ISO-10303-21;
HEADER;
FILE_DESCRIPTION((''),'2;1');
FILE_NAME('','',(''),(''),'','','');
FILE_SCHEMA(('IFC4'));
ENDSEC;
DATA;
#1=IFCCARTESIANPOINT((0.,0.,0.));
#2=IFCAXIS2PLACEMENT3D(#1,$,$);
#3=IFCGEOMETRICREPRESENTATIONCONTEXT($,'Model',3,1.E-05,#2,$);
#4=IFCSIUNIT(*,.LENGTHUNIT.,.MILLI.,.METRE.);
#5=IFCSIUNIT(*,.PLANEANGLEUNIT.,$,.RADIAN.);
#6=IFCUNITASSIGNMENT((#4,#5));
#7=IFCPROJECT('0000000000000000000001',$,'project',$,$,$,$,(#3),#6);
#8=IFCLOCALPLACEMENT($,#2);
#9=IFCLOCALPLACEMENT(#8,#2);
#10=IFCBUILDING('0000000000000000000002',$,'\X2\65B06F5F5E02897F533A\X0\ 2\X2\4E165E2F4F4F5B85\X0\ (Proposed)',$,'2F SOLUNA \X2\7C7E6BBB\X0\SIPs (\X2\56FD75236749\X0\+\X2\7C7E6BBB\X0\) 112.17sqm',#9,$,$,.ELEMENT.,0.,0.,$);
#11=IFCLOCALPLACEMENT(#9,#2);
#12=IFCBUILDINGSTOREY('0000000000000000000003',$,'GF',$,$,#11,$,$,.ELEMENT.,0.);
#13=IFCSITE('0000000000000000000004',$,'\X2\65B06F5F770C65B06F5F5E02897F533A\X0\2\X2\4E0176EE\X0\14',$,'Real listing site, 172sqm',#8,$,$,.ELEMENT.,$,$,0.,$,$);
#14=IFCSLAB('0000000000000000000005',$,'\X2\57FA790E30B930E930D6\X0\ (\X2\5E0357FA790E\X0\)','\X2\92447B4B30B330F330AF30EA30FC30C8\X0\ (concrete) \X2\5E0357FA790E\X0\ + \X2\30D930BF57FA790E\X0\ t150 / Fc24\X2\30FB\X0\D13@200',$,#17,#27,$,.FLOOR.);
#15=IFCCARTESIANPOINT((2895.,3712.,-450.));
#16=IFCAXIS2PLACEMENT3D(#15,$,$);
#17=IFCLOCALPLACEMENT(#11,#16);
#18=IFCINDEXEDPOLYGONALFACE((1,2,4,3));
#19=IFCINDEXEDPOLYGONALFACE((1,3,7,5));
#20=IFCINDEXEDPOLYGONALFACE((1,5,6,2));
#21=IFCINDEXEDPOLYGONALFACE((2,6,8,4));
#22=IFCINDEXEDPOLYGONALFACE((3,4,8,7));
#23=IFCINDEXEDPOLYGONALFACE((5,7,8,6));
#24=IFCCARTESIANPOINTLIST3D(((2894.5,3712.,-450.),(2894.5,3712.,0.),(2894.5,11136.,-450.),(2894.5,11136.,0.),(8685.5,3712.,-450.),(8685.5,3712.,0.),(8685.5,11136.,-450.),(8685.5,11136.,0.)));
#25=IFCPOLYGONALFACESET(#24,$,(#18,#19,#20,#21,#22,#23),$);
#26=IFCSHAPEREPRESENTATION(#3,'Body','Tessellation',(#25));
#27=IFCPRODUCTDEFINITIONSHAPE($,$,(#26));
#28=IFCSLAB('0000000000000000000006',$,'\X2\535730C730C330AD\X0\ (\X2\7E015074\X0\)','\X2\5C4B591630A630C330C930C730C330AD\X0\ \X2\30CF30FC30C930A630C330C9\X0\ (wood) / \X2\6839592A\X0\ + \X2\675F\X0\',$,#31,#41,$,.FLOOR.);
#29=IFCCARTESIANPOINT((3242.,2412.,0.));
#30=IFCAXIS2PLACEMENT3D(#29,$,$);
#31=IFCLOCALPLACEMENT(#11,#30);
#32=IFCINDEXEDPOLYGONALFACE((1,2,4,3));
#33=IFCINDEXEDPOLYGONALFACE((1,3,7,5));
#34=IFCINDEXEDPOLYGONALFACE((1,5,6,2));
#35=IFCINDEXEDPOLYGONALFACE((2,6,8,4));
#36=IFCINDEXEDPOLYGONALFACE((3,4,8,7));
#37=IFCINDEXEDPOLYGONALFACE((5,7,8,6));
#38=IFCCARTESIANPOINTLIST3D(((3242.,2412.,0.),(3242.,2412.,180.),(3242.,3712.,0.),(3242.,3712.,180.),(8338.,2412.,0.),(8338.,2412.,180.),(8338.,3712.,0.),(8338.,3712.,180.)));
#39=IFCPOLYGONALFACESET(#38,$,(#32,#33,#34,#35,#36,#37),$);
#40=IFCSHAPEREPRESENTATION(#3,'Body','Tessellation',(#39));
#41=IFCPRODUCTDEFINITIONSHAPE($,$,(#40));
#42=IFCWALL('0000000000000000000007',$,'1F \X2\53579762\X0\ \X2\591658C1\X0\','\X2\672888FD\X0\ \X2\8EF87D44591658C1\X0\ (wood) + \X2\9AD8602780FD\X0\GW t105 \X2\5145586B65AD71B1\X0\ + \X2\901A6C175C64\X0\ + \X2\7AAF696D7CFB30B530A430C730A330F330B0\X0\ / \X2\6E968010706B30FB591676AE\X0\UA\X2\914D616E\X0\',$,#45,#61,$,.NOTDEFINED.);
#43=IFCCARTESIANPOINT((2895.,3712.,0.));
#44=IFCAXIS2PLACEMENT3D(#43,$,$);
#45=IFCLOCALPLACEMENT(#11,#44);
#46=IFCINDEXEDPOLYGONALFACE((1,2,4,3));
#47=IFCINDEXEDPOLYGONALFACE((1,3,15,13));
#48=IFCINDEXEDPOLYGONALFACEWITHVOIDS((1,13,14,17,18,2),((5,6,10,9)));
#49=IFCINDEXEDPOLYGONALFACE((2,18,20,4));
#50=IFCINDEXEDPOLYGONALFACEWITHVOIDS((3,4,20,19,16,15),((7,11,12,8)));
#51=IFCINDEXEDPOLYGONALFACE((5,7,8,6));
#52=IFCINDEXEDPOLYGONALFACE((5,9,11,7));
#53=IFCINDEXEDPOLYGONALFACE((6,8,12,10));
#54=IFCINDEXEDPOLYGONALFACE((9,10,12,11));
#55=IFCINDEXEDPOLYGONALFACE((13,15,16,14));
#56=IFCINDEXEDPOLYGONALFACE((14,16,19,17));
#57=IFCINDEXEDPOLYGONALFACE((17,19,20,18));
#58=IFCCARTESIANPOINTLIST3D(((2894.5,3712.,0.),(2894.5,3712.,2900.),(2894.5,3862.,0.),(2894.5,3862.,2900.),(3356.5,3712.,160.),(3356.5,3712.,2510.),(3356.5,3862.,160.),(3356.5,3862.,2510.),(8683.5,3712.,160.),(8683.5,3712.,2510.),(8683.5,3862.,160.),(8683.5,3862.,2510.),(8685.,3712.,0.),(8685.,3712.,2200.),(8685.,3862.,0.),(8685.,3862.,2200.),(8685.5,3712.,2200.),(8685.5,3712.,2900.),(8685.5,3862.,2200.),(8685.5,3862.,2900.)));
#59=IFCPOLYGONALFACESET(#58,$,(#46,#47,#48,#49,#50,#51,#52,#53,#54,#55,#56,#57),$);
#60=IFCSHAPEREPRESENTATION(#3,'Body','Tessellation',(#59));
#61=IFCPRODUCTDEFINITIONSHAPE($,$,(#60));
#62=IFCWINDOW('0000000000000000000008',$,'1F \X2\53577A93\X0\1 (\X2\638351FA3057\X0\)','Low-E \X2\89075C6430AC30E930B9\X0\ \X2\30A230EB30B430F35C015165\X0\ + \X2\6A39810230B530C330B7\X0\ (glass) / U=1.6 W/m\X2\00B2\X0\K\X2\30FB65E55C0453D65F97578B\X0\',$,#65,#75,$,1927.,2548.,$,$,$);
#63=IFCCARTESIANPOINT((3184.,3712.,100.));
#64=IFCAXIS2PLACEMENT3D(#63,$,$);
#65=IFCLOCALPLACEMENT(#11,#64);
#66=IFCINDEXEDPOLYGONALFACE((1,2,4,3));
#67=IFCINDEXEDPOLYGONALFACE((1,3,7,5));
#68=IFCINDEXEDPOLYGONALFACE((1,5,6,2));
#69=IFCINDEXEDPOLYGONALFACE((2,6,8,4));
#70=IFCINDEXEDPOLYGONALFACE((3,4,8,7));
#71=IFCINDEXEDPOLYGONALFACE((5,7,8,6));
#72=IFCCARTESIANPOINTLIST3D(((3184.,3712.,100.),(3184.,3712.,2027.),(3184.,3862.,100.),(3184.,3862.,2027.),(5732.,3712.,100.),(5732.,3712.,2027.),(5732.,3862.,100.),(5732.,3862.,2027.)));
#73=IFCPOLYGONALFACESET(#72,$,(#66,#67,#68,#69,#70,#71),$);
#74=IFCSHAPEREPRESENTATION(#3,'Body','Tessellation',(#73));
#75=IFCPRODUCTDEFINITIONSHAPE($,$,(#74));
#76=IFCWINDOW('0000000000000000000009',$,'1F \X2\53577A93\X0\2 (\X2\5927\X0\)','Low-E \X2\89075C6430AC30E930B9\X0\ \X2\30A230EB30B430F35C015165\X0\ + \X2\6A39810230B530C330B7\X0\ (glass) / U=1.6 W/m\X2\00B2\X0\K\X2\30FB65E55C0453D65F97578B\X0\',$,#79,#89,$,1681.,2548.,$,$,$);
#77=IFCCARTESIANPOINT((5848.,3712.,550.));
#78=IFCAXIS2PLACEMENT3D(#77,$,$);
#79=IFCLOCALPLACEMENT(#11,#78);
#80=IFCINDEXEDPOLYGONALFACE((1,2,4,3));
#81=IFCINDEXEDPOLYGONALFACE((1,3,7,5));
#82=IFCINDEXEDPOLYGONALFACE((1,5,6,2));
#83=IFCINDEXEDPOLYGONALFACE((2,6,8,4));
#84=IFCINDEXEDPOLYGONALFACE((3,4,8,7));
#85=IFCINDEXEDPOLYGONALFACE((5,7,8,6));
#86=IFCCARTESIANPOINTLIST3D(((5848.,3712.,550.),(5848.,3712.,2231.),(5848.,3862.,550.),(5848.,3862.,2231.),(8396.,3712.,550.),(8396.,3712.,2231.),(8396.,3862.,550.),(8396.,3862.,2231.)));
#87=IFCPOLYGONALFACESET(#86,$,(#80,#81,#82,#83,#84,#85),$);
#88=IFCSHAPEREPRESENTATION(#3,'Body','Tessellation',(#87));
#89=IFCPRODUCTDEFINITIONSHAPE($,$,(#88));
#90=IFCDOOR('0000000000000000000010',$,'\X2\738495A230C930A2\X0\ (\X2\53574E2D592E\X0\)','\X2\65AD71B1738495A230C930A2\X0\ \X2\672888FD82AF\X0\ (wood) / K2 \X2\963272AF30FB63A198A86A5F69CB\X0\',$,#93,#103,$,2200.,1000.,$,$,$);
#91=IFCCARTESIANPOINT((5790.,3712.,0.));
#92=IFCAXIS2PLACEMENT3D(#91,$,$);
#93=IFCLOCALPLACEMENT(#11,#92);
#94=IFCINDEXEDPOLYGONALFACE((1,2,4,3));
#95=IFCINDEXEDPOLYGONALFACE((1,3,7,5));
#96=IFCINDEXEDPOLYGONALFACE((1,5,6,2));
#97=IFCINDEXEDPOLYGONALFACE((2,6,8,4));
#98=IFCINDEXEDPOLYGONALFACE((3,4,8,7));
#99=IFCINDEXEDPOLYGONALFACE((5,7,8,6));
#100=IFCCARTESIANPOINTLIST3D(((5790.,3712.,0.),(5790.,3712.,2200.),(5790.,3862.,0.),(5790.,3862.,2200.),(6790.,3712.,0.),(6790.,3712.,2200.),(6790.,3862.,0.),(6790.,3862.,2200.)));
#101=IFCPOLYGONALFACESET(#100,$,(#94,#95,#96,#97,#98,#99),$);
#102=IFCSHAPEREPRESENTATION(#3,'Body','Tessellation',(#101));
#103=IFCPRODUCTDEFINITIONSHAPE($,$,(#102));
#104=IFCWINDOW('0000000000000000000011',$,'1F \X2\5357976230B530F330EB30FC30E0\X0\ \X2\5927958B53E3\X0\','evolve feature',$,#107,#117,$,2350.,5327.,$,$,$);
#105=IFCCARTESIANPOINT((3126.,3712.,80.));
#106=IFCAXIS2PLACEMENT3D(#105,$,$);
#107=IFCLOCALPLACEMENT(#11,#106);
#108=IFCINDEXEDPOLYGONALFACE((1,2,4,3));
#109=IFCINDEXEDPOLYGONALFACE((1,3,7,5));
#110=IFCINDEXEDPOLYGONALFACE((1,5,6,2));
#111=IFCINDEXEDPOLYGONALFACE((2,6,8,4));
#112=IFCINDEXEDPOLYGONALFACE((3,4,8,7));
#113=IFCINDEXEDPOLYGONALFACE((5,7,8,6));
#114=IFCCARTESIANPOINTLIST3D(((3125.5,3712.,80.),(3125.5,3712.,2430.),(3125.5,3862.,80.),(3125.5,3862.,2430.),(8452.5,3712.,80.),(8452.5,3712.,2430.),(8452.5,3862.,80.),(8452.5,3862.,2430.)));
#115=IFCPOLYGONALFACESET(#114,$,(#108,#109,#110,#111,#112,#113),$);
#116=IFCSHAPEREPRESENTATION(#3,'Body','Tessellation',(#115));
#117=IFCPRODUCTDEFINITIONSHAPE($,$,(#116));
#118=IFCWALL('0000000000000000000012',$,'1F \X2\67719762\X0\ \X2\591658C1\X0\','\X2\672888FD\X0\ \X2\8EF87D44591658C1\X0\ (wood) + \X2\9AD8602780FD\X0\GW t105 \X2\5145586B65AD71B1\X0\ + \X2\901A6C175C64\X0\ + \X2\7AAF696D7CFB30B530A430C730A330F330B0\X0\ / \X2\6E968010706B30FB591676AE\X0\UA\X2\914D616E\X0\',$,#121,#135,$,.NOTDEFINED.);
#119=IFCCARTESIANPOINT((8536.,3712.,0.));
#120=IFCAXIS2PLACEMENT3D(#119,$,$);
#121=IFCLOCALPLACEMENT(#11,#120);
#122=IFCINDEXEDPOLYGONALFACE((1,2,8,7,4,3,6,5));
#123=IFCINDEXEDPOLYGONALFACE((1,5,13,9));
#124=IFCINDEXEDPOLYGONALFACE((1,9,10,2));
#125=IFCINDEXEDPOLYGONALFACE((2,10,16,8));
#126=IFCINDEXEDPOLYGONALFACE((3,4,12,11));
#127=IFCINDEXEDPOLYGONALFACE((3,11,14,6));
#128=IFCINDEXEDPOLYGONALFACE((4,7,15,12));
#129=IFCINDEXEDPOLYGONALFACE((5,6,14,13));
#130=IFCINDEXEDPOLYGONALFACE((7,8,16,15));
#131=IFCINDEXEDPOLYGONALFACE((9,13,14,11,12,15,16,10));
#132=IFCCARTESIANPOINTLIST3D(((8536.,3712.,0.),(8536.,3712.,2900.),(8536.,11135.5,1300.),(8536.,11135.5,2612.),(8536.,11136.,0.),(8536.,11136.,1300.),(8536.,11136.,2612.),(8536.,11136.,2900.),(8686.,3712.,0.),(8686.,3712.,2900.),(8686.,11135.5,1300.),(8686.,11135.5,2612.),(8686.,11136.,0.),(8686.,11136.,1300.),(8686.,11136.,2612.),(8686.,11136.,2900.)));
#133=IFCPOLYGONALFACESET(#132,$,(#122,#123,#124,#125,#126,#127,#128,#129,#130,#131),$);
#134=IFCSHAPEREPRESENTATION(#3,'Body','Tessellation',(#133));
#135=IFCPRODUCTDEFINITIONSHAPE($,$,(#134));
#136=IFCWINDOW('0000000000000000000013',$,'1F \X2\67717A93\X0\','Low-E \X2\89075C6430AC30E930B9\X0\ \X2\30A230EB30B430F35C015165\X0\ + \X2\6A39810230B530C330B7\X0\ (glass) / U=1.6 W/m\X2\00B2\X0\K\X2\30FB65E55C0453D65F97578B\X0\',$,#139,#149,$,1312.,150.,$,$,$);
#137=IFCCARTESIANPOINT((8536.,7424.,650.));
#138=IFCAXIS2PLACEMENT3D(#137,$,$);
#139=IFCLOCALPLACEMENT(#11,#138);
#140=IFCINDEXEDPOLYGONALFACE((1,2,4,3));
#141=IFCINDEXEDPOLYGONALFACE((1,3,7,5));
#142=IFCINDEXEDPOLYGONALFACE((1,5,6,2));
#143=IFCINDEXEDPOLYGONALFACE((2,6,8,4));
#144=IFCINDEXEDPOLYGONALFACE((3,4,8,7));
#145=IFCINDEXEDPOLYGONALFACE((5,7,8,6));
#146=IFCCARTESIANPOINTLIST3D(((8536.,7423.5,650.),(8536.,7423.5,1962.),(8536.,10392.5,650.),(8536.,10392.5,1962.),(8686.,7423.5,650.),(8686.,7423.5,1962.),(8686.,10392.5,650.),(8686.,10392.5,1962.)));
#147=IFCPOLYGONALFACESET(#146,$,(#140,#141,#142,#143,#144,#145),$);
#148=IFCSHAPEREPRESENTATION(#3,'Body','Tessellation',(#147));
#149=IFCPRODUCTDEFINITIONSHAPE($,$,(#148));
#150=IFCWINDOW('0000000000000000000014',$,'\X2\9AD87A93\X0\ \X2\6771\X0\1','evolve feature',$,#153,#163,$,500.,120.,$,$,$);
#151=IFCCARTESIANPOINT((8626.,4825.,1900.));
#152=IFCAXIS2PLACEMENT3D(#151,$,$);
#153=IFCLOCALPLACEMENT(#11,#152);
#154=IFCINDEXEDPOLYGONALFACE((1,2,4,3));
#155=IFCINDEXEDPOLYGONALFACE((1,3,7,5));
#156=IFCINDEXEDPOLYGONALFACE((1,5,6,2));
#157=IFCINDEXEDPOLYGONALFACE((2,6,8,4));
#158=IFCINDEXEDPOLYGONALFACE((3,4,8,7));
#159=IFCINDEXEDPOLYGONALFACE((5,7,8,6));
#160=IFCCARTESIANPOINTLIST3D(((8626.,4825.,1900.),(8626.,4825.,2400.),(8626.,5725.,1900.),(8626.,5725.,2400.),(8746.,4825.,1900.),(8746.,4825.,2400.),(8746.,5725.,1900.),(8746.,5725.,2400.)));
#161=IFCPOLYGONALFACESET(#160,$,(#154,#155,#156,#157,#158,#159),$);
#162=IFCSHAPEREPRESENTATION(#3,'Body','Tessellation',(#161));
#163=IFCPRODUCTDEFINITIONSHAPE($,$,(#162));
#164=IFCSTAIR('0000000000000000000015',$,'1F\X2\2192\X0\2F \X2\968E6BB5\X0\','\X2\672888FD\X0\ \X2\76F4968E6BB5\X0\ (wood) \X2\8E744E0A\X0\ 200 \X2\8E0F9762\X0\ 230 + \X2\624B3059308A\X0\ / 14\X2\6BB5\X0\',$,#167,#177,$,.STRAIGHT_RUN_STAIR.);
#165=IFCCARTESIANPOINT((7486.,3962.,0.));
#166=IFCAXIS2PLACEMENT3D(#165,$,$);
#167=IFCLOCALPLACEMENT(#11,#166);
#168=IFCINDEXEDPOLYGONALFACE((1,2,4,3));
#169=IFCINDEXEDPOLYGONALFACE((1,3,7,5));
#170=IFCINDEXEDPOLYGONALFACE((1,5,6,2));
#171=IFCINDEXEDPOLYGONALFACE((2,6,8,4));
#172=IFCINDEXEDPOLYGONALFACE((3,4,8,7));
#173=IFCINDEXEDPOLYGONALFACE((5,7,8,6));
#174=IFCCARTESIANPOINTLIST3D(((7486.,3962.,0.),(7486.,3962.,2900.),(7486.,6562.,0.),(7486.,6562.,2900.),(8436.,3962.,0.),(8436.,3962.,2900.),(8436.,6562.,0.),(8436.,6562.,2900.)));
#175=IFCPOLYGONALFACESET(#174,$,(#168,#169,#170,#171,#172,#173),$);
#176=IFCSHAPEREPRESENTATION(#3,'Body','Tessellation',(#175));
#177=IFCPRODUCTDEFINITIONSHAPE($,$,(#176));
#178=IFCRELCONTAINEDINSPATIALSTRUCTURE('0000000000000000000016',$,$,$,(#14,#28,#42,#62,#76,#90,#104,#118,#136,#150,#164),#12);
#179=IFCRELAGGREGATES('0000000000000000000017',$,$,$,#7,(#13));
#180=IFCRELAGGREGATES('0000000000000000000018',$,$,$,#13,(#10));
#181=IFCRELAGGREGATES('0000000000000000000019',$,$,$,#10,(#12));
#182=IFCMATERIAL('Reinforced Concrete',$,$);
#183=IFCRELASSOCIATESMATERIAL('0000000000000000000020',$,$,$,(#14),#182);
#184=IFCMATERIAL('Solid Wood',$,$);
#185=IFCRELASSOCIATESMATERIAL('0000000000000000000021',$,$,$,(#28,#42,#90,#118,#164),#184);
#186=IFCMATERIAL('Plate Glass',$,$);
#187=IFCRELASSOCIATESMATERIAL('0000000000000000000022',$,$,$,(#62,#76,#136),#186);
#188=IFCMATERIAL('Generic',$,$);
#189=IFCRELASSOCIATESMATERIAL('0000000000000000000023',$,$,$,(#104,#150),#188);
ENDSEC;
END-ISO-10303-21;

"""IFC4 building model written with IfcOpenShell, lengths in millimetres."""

from ifc_helpers import new_model, si_unit, frame, frame_2d, origin, place, context, project, spatial, rectangle, extrude, material, element, fill, save


model = new_model("IFC4")

# Units and contexts
model_context = context("Model", 3, precision=1e-05, world=origin())
ifc_project = project(units=[si_unit("LENGTHUNIT", "METRE", prefix="MILLI"), si_unit("PLANEANGLEUNIT", "RADIAN")], contexts=[model_context])

# Site, building, storey
site_placement = place(None, origin())
site = spatial("IfcSite", under=ifc_project, at=site_placement, Name="新潟県新潟市西区2丁目14", ObjectType="Real listing site, 172sqm", CompositionType="ELEMENT", RefElevation=0.0)
building_placement = place(site_placement, origin())
building = spatial("IfcBuilding", under=site, at=building_placement, Name="新潟市西区 2世帯住宅 (Proposed)", ObjectType="2F SOLUNA 籾殻SIPs (国産杉+籾殻) 112.17sqm", CompositionType="ELEMENT", ElevationOfRefHeight=0.0, ElevationOfTerrain=0.0)
storey_placement = place(building_placement, origin())
storey = spatial("IfcBuildingStorey", under=building, at=storey_placement, Name="GF", CompositionType="ELEMENT", Elevation=0.0)

# Slabs
ifc_material_1 = material(Name="Reinforced Concrete")
slab_1_placement = place(storey_placement, frame((2895.0, 3712.0, -450.0)))
element("IfcSlab", 1, at=slab_1_placement, inside=storey, material=ifc_material_1, Name="基礎スラブ (布基礎)", Description="鉄筋コンクリート (concrete) 布基礎 + ベタ基礎 t150 / Fc24・D13@200", PredefinedType="FLOOR", context=model_context, shape_type="SweptSolid", body=[
    extrude(rectangle(XDim=5791.0, YDim=7424.0, at=frame_2d((2895.0, 3712.0))), frame((2895.0, 3712.0, -450.0)), (0.0, 0.0, 1.0), 450.0),
])
ifc_material_2 = material(Name="Solid Wood")
slab_2_placement = place(storey_placement, frame((3242.0, 2412.0, 0.0)))
element("IfcSlab", 2, at=slab_2_placement, inside=storey, material=ifc_material_2, Name="南デッキ (縁側)", Description="屋外ウッドデッキ ハードウッド (wood) / 根太 + 束", PredefinedType="FLOOR", context=model_context, shape_type="SweptSolid", body=[
    extrude(rectangle(XDim=5096.0, YDim=1300.0, at=frame_2d((2548.0, 650.0))), frame((3242.0, 2412.0, 0.0)), (0.0, 0.0, 1.0), 180.0),
])
ifc_material_3 = material(Name="Generic")

# Wall, openings, windows, door
wall_1_placement = place(storey_placement, frame((2895.0, 3712.0, 0.0)))
wall_1 = element("IfcWall", 3, at=wall_1_placement, inside=storey, material=ifc_material_2, Name="1F 南面 外壁", Description="木製 軸組外壁 (wood) + 高性能GW t105 充填断熱 + 通気層 + 窯業系サイディング / 準耐火・外皮UA配慮", PredefinedType="NOTDEFINED", context=model_context, shape_type="SweptSolid", body=[
    extrude(rectangle(XDim=5791.0, YDim=150.0, at=frame_2d((2895.0, 75.0))), frame((2895.0, 3712.0, 0.0)), (0.0, 0.0, 1.0), 2900.0),
])
opening_1_placement = place(storey_placement, frame((3184.0, 3712.0, 100.0)))
opening_1 = element("IfcOpeningElement", 4, at=opening_1_placement, cuts=wall_1, PredefinedType="NOTDEFINED", context=model_context, shape_type="SweptSolid", body=[
    extrude(rectangle(XDim=2548.0, YDim=150.0, at=frame_2d((1274.0, 75.0))), frame((3184.0, 3712.0, 100.0)), (0.0, 0.0, 1.0), 1927.0),
])
opening_2_placement = place(storey_placement, frame((5848.0, 3712.0, 550.0)))
opening_2 = element("IfcOpeningElement", 5, at=opening_2_placement, cuts=wall_1, PredefinedType="NOTDEFINED", context=model_context, shape_type="SweptSolid", body=[
    extrude(rectangle(XDim=2548.0, YDim=150.0, at=frame_2d((1274.0, 75.0))), frame((5848.0, 3712.0, 550.0)), (0.0, 0.0, 1.0), 1681.0),
])
opening_3_placement = place(storey_placement, frame((5790.0, 3712.0, 0.0)))
opening_3 = element("IfcOpeningElement", 6, at=opening_3_placement, cuts=wall_1, PredefinedType="NOTDEFINED", context=model_context, shape_type="SweptSolid", body=[
    extrude(rectangle(XDim=1000.0, YDim=150.0, at=frame_2d((500.0, 75.0))), frame((5790.0, 3712.0, 0.0)), (0.0, 0.0, 1.0), 2200.0),
])
opening_4_placement = place(storey_placement, frame((3126.0, 3712.0, 80.0)))
opening_4 = element("IfcOpeningElement", 7, at=opening_4_placement, cuts=wall_1, PredefinedType="NOTDEFINED", context=model_context, shape_type="SweptSolid", body=[
    extrude(rectangle(XDim=5327.0, YDim=150.0, at=frame_2d((2663.0, 75.0))), frame((3126.0, 3712.0, 80.0)), (0.0, 0.0, 1.0), 2350.0),
])
ifc_material_4 = material(Name="Plate Glass")
window_1_placement = place(storey_placement, frame((3184.0, 3712.0, 100.0)))
window_1 = element("IfcWindow", 8, at=window_1_placement, inside=storey, material=ifc_material_4, Name="1F 南窓1 (掃出し)", Description="Low-E 複層ガラス アルゴン封入 + 樹脂サッシ (glass) / U=1.6 W/m²K・日射取得型", OverallHeight=1927.0, OverallWidth=2548.0, context=model_context, shape_type="SweptSolid", body=[
    extrude(rectangle(XDim=2548.0, YDim=150.0, at=frame_2d((1274.0, 75.0))), frame((3184.0, 3712.0, 100.0)), (0.0, 0.0, 1.0), 1927.0),
])
fill(opening_1, window_1)
window_2_placement = place(storey_placement, frame((5848.0, 3712.0, 550.0)))
window_2 = element("IfcWindow", 9, at=window_2_placement, inside=storey, material=ifc_material_4, Name="1F 南窓2 (大)", Description="Low-E 複層ガラス アルゴン封入 + 樹脂サッシ (glass) / U=1.6 W/m²K・日射取得型", OverallHeight=1681.0, OverallWidth=2548.0, context=model_context, shape_type="SweptSolid", body=[
    extrude(rectangle(XDim=2548.0, YDim=150.0, at=frame_2d((1274.0, 75.0))), frame((5848.0, 3712.0, 550.0)), (0.0, 0.0, 1.0), 1681.0),
])
fill(opening_2, window_2)
door_placement = place(storey_placement, frame((5790.0, 3712.0, 0.0)))
door = element("IfcDoor", 10, at=door_placement, inside=storey, material=ifc_material_2, Name="玄関ドア (南中央)", Description="断熱玄関ドア 木製芯 (wood) / K2 防犯・採風機構", OverallHeight=2200.0, OverallWidth=1000.0, context=model_context, shape_type="SweptSolid", body=[
    extrude(rectangle(XDim=1000.0, YDim=150.0, at=frame_2d((500.0, 75.0))), frame((5790.0, 3712.0, 0.0)), (0.0, 0.0, 1.0), 2200.0),
])
fill(opening_3, door)
window_3_placement = place(storey_placement, frame((3126.0, 3712.0, 80.0)))
window_3 = element("IfcWindow", 11, at=window_3_placement, inside=storey, material=ifc_material_3, Name="1F 南面サンルーム 大開口", Description="evolve feature", OverallHeight=2350.0, OverallWidth=5327.0, context=model_context, shape_type="SweptSolid", body=[
    extrude(rectangle(XDim=5327.0, YDim=150.0, at=frame_2d((2663.0, 75.0))), frame((3126.0, 3712.0, 80.0)), (0.0, 0.0, 1.0), 2350.0),
])
fill(opening_4, window_3)

# Wall, openings, windows
wall_2_placement = place(storey_placement, frame((8536.0, 3712.0, 0.0)))
wall_2 = element("IfcWall", 12, at=wall_2_placement, inside=storey, material=ifc_material_2, Name="1F 東面 外壁", Description="木製 軸組外壁 (wood) + 高性能GW t105 充填断熱 + 通気層 + 窯業系サイディング / 準耐火・外皮UA配慮", PredefinedType="NOTDEFINED", context=model_context, shape_type="SweptSolid", body=[
    extrude(rectangle(XDim=150.0, YDim=7424.0, at=frame_2d((75.0, 3712.0))), frame((8536.0, 3712.0, 0.0)), (0.0, 0.0, 1.0), 2900.0),
])
opening_5_placement = place(storey_placement, frame((8536.0, 7424.0, 650.0)))
opening_5 = element("IfcOpeningElement", 13, at=opening_5_placement, cuts=wall_2, PredefinedType="NOTDEFINED", context=model_context, shape_type="SweptSolid", body=[
    extrude(rectangle(XDim=150.0, YDim=2969.0, at=frame_2d((75.0, 1484.0))), frame((8536.0, 7424.0, 650.0)), (0.0, 0.0, 1.0), 1312.0),
])
opening_6_placement = place(storey_placement, frame((8626.0, 4825.0, 1900.0)))
opening_6 = element("IfcOpeningElement", 14, at=opening_6_placement, cuts=wall_2, PredefinedType="NOTDEFINED", context=model_context, shape_type="SweptSolid", body=[
    extrude(rectangle(XDim=120.0, YDim=900.0, at=frame_2d((60.0, 450.0))), frame((8626.0, 4825.0, 1900.0)), (0.0, 0.0, 1.0), 500.0),
])
window_4_placement = place(storey_placement, frame((8536.0, 7424.0, 650.0)))
window_4 = element("IfcWindow", 15, at=window_4_placement, inside=storey, material=ifc_material_4, Name="1F 東窓", Description="Low-E 複層ガラス アルゴン封入 + 樹脂サッシ (glass) / U=1.6 W/m²K・日射取得型", OverallHeight=1312.0, OverallWidth=150.0, context=model_context, shape_type="SweptSolid", body=[
    extrude(rectangle(XDim=150.0, YDim=2969.0, at=frame_2d((75.0, 1484.0))), frame((8536.0, 7424.0, 650.0)), (0.0, 0.0, 1.0), 1312.0),
])
fill(opening_5, window_4)
window_5_placement = place(storey_placement, frame((8626.0, 4825.0, 1900.0)))
window_5 = element("IfcWindow", 16, at=window_5_placement, inside=storey, material=ifc_material_3, Name="高窓 東1", Description="evolve feature", OverallHeight=500.0, OverallWidth=120.0, context=model_context, shape_type="SweptSolid", body=[
    extrude(rectangle(XDim=120.0, YDim=900.0, at=frame_2d((60.0, 450.0))), frame((8626.0, 4825.0, 1900.0)), (0.0, 0.0, 1.0), 500.0),
])
fill(opening_6, window_5)

# Stair
stair_placement = place(storey_placement, frame((7486.0, 3962.0, 0.0)))
element("IfcStair", 17, at=stair_placement, inside=storey, material=ifc_material_2, Name="1F→2F 階段", Description="木製 直階段 (wood) 蹴上 200 踏面 230 + 手すり / 14段", PredefinedType="STRAIGHT_RUN_STAIR", context=model_context, shape_type="SweptSolid", body=[
    extrude(rectangle(XDim=950.0, YDim=2600.0, at=frame_2d((475.0, 1300.0))), frame((7486.0, 3962.0, 0.0)), (0.0, 0.0, 1.0), 2900.0),
])

save(model, "model.ifc")
